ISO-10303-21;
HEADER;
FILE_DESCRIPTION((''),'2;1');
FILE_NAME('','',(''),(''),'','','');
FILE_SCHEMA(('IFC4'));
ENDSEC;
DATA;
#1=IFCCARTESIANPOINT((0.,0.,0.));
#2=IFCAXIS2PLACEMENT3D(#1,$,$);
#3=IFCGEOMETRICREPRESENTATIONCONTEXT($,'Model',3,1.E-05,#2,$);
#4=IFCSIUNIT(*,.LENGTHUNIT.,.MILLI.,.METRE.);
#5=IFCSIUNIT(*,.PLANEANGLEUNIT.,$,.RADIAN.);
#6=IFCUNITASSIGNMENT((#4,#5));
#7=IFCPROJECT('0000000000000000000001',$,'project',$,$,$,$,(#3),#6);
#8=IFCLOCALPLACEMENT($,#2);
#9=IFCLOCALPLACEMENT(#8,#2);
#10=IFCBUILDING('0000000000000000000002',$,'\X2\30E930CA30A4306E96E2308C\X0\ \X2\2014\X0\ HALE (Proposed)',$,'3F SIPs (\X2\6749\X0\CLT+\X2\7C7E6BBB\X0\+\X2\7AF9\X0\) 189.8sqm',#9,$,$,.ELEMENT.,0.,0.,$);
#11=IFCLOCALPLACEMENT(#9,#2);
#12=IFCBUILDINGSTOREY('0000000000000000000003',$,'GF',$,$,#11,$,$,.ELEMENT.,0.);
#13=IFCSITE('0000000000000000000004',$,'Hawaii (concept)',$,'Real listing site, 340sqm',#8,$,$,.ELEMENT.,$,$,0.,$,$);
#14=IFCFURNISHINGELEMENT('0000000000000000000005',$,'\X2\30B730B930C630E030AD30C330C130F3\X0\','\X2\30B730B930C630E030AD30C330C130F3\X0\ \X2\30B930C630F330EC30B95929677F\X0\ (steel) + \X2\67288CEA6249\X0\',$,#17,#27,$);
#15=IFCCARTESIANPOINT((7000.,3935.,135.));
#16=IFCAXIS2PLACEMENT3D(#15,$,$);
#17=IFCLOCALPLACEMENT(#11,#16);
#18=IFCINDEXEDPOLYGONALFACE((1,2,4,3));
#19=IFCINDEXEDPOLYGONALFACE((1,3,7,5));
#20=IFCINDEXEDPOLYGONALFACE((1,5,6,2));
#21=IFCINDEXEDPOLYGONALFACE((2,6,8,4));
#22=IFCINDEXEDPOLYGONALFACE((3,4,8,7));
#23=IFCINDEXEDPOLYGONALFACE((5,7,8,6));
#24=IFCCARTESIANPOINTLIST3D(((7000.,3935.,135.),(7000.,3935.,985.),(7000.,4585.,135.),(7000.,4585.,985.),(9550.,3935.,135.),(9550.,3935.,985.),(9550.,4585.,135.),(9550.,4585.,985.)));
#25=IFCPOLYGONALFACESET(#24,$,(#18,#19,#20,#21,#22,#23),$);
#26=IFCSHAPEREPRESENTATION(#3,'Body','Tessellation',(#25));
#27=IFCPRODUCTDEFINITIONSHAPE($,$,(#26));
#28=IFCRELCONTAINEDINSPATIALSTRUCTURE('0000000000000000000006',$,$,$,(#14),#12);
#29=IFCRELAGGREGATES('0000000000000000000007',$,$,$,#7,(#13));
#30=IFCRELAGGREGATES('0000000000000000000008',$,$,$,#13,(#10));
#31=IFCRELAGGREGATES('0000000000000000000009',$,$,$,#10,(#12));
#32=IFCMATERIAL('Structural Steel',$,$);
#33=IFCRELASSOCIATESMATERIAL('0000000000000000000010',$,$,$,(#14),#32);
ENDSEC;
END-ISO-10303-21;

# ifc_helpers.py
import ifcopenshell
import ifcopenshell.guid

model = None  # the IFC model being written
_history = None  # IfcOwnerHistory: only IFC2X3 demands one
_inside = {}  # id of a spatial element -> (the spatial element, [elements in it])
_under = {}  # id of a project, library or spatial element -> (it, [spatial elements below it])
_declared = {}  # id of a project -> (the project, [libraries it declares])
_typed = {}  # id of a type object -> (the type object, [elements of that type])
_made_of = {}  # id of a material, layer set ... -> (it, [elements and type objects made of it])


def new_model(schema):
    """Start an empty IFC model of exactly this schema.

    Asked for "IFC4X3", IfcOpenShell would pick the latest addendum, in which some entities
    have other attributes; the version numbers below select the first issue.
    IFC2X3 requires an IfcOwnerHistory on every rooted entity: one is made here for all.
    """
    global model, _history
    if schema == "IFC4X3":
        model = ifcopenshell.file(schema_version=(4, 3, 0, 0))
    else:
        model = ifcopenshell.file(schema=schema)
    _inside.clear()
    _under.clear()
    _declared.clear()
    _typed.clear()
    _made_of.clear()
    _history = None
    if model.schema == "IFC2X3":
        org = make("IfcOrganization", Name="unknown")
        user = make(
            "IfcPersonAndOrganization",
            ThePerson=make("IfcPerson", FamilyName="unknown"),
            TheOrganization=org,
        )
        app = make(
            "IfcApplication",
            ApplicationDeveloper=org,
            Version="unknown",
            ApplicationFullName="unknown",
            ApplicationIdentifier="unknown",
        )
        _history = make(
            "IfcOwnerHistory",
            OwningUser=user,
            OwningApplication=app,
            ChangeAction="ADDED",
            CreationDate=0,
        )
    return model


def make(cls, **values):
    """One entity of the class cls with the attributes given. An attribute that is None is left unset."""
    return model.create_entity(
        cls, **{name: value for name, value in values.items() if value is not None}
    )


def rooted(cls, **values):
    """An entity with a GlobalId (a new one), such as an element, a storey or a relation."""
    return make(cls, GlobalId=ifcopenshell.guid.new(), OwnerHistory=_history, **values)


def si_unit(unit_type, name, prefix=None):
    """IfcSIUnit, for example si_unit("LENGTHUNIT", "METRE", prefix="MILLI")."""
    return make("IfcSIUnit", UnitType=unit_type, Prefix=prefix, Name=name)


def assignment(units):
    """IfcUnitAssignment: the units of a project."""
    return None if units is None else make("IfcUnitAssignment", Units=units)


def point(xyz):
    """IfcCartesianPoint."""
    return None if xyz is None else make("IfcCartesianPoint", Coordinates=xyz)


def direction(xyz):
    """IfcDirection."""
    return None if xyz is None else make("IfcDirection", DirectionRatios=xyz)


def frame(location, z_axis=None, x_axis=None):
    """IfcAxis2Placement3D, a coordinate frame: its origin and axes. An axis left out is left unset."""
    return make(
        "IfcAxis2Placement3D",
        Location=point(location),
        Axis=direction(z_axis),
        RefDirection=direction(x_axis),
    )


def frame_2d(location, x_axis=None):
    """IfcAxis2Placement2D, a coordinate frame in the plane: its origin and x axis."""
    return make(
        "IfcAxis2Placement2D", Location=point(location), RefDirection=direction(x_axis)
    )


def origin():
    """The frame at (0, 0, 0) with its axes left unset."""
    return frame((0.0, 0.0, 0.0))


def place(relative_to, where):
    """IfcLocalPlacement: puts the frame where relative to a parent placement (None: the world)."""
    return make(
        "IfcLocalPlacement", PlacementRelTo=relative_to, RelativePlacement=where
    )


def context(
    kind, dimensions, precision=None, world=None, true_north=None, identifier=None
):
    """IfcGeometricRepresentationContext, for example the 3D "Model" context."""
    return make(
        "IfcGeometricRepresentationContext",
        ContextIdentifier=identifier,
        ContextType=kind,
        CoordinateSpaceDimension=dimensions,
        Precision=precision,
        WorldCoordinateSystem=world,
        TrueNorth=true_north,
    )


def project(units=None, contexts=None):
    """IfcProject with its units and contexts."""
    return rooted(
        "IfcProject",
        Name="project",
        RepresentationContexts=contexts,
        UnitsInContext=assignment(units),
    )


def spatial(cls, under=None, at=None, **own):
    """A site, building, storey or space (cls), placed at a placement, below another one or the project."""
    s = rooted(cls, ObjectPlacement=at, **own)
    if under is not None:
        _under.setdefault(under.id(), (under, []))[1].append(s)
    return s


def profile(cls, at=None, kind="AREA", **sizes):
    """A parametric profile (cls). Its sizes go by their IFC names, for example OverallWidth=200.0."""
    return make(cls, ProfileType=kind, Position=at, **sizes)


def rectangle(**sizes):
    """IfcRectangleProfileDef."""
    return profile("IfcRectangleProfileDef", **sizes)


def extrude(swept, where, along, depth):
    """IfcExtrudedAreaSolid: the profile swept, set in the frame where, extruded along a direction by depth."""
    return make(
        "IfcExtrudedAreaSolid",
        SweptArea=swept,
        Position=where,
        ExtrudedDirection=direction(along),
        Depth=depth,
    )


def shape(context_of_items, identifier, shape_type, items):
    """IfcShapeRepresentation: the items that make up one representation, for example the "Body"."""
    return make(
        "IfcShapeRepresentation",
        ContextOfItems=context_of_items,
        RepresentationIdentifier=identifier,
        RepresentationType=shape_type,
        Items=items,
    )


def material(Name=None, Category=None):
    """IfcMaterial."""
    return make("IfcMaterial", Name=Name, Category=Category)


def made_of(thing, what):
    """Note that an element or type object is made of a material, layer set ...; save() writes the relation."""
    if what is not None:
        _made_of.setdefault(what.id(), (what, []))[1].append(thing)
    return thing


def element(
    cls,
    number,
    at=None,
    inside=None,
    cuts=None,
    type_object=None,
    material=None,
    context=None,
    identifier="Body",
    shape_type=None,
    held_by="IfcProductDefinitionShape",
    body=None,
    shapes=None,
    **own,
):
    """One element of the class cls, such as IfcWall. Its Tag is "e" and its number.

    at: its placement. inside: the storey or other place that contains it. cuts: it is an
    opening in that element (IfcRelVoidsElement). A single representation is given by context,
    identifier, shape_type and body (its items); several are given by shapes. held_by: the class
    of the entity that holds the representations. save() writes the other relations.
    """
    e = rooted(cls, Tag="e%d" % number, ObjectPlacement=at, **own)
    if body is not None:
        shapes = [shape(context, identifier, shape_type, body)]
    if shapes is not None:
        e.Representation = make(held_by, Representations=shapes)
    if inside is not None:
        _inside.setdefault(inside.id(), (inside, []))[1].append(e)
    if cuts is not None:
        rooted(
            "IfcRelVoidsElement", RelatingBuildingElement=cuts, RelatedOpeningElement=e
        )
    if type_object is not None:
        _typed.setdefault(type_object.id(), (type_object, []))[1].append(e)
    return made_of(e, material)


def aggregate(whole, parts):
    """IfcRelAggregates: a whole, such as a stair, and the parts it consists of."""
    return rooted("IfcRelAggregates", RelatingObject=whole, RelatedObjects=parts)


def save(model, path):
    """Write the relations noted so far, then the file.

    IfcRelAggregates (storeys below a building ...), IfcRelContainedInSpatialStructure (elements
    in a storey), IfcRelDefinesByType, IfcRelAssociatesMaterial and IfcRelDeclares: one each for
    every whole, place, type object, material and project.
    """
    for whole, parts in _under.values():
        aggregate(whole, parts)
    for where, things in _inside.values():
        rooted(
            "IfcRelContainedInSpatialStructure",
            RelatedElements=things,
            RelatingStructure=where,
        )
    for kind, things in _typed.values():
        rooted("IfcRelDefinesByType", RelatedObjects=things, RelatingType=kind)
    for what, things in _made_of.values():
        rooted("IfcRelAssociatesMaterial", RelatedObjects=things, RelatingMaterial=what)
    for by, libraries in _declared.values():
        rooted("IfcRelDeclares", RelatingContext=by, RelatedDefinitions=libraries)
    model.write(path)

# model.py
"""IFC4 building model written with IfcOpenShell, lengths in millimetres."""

from ifc_helpers import new_model, si_unit, frame, frame_2d, origin, place, context, project, spatial, rectangle, extrude, material, element, save


model = new_model("IFC4")

# Units and contexts
model_context = context("Model", 3, precision=1e-05, world=origin())
ifc_project = project(units=[si_unit("LENGTHUNIT", "METRE", prefix="MILLI"), si_unit("PLANEANGLEUNIT", "RADIAN")], contexts=[model_context])

# Site, building, storey
site_placement = place(None, origin())
site = spatial("IfcSite", under=ifc_project, at=site_placement, Name="Hawaii (concept)", ObjectType="Real listing site, 340sqm", CompositionType="ELEMENT", RefElevation=0.0)
building_placement = place(site_placement, origin())
building = spatial("IfcBuilding", under=site, at=building_placement, Name="ラナイの離れ — HALE (Proposed)", ObjectType="3F SIPs (杉CLT+籾殻+竹) 189.8sqm", CompositionType="ELEMENT", ElevationOfRefHeight=0.0, ElevationOfTerrain=0.0)
storey_placement = place(building_placement, origin())
storey = spatial("IfcBuildingStorey", under=building, at=storey_placement, Name="GF", CompositionType="ELEMENT", Elevation=0.0)

# Furnishing element
ifc_material_1 = material(Name="Structural Steel")
furnishing_1_placement = place(storey_placement, frame((7000.0, 3935.0, 135.0)))
element("IfcFurnishingElement", 1, at=furnishing_1_placement, inside=storey, material=ifc_material_1, Name="システムキッチン", Description="システムキッチン ステンレス天板 (steel) + 木質扉", context=model_context, shape_type="SweptSolid", body=[
    extrude(rectangle(XDim=2550.0, YDim=650.0, at=frame_2d((1275.0, 325.0))), frame((7000.0, 3935.0, 135.0)), (0.0, 0.0, 1.0), 850.0),
])

save(model, "model.ifc")
